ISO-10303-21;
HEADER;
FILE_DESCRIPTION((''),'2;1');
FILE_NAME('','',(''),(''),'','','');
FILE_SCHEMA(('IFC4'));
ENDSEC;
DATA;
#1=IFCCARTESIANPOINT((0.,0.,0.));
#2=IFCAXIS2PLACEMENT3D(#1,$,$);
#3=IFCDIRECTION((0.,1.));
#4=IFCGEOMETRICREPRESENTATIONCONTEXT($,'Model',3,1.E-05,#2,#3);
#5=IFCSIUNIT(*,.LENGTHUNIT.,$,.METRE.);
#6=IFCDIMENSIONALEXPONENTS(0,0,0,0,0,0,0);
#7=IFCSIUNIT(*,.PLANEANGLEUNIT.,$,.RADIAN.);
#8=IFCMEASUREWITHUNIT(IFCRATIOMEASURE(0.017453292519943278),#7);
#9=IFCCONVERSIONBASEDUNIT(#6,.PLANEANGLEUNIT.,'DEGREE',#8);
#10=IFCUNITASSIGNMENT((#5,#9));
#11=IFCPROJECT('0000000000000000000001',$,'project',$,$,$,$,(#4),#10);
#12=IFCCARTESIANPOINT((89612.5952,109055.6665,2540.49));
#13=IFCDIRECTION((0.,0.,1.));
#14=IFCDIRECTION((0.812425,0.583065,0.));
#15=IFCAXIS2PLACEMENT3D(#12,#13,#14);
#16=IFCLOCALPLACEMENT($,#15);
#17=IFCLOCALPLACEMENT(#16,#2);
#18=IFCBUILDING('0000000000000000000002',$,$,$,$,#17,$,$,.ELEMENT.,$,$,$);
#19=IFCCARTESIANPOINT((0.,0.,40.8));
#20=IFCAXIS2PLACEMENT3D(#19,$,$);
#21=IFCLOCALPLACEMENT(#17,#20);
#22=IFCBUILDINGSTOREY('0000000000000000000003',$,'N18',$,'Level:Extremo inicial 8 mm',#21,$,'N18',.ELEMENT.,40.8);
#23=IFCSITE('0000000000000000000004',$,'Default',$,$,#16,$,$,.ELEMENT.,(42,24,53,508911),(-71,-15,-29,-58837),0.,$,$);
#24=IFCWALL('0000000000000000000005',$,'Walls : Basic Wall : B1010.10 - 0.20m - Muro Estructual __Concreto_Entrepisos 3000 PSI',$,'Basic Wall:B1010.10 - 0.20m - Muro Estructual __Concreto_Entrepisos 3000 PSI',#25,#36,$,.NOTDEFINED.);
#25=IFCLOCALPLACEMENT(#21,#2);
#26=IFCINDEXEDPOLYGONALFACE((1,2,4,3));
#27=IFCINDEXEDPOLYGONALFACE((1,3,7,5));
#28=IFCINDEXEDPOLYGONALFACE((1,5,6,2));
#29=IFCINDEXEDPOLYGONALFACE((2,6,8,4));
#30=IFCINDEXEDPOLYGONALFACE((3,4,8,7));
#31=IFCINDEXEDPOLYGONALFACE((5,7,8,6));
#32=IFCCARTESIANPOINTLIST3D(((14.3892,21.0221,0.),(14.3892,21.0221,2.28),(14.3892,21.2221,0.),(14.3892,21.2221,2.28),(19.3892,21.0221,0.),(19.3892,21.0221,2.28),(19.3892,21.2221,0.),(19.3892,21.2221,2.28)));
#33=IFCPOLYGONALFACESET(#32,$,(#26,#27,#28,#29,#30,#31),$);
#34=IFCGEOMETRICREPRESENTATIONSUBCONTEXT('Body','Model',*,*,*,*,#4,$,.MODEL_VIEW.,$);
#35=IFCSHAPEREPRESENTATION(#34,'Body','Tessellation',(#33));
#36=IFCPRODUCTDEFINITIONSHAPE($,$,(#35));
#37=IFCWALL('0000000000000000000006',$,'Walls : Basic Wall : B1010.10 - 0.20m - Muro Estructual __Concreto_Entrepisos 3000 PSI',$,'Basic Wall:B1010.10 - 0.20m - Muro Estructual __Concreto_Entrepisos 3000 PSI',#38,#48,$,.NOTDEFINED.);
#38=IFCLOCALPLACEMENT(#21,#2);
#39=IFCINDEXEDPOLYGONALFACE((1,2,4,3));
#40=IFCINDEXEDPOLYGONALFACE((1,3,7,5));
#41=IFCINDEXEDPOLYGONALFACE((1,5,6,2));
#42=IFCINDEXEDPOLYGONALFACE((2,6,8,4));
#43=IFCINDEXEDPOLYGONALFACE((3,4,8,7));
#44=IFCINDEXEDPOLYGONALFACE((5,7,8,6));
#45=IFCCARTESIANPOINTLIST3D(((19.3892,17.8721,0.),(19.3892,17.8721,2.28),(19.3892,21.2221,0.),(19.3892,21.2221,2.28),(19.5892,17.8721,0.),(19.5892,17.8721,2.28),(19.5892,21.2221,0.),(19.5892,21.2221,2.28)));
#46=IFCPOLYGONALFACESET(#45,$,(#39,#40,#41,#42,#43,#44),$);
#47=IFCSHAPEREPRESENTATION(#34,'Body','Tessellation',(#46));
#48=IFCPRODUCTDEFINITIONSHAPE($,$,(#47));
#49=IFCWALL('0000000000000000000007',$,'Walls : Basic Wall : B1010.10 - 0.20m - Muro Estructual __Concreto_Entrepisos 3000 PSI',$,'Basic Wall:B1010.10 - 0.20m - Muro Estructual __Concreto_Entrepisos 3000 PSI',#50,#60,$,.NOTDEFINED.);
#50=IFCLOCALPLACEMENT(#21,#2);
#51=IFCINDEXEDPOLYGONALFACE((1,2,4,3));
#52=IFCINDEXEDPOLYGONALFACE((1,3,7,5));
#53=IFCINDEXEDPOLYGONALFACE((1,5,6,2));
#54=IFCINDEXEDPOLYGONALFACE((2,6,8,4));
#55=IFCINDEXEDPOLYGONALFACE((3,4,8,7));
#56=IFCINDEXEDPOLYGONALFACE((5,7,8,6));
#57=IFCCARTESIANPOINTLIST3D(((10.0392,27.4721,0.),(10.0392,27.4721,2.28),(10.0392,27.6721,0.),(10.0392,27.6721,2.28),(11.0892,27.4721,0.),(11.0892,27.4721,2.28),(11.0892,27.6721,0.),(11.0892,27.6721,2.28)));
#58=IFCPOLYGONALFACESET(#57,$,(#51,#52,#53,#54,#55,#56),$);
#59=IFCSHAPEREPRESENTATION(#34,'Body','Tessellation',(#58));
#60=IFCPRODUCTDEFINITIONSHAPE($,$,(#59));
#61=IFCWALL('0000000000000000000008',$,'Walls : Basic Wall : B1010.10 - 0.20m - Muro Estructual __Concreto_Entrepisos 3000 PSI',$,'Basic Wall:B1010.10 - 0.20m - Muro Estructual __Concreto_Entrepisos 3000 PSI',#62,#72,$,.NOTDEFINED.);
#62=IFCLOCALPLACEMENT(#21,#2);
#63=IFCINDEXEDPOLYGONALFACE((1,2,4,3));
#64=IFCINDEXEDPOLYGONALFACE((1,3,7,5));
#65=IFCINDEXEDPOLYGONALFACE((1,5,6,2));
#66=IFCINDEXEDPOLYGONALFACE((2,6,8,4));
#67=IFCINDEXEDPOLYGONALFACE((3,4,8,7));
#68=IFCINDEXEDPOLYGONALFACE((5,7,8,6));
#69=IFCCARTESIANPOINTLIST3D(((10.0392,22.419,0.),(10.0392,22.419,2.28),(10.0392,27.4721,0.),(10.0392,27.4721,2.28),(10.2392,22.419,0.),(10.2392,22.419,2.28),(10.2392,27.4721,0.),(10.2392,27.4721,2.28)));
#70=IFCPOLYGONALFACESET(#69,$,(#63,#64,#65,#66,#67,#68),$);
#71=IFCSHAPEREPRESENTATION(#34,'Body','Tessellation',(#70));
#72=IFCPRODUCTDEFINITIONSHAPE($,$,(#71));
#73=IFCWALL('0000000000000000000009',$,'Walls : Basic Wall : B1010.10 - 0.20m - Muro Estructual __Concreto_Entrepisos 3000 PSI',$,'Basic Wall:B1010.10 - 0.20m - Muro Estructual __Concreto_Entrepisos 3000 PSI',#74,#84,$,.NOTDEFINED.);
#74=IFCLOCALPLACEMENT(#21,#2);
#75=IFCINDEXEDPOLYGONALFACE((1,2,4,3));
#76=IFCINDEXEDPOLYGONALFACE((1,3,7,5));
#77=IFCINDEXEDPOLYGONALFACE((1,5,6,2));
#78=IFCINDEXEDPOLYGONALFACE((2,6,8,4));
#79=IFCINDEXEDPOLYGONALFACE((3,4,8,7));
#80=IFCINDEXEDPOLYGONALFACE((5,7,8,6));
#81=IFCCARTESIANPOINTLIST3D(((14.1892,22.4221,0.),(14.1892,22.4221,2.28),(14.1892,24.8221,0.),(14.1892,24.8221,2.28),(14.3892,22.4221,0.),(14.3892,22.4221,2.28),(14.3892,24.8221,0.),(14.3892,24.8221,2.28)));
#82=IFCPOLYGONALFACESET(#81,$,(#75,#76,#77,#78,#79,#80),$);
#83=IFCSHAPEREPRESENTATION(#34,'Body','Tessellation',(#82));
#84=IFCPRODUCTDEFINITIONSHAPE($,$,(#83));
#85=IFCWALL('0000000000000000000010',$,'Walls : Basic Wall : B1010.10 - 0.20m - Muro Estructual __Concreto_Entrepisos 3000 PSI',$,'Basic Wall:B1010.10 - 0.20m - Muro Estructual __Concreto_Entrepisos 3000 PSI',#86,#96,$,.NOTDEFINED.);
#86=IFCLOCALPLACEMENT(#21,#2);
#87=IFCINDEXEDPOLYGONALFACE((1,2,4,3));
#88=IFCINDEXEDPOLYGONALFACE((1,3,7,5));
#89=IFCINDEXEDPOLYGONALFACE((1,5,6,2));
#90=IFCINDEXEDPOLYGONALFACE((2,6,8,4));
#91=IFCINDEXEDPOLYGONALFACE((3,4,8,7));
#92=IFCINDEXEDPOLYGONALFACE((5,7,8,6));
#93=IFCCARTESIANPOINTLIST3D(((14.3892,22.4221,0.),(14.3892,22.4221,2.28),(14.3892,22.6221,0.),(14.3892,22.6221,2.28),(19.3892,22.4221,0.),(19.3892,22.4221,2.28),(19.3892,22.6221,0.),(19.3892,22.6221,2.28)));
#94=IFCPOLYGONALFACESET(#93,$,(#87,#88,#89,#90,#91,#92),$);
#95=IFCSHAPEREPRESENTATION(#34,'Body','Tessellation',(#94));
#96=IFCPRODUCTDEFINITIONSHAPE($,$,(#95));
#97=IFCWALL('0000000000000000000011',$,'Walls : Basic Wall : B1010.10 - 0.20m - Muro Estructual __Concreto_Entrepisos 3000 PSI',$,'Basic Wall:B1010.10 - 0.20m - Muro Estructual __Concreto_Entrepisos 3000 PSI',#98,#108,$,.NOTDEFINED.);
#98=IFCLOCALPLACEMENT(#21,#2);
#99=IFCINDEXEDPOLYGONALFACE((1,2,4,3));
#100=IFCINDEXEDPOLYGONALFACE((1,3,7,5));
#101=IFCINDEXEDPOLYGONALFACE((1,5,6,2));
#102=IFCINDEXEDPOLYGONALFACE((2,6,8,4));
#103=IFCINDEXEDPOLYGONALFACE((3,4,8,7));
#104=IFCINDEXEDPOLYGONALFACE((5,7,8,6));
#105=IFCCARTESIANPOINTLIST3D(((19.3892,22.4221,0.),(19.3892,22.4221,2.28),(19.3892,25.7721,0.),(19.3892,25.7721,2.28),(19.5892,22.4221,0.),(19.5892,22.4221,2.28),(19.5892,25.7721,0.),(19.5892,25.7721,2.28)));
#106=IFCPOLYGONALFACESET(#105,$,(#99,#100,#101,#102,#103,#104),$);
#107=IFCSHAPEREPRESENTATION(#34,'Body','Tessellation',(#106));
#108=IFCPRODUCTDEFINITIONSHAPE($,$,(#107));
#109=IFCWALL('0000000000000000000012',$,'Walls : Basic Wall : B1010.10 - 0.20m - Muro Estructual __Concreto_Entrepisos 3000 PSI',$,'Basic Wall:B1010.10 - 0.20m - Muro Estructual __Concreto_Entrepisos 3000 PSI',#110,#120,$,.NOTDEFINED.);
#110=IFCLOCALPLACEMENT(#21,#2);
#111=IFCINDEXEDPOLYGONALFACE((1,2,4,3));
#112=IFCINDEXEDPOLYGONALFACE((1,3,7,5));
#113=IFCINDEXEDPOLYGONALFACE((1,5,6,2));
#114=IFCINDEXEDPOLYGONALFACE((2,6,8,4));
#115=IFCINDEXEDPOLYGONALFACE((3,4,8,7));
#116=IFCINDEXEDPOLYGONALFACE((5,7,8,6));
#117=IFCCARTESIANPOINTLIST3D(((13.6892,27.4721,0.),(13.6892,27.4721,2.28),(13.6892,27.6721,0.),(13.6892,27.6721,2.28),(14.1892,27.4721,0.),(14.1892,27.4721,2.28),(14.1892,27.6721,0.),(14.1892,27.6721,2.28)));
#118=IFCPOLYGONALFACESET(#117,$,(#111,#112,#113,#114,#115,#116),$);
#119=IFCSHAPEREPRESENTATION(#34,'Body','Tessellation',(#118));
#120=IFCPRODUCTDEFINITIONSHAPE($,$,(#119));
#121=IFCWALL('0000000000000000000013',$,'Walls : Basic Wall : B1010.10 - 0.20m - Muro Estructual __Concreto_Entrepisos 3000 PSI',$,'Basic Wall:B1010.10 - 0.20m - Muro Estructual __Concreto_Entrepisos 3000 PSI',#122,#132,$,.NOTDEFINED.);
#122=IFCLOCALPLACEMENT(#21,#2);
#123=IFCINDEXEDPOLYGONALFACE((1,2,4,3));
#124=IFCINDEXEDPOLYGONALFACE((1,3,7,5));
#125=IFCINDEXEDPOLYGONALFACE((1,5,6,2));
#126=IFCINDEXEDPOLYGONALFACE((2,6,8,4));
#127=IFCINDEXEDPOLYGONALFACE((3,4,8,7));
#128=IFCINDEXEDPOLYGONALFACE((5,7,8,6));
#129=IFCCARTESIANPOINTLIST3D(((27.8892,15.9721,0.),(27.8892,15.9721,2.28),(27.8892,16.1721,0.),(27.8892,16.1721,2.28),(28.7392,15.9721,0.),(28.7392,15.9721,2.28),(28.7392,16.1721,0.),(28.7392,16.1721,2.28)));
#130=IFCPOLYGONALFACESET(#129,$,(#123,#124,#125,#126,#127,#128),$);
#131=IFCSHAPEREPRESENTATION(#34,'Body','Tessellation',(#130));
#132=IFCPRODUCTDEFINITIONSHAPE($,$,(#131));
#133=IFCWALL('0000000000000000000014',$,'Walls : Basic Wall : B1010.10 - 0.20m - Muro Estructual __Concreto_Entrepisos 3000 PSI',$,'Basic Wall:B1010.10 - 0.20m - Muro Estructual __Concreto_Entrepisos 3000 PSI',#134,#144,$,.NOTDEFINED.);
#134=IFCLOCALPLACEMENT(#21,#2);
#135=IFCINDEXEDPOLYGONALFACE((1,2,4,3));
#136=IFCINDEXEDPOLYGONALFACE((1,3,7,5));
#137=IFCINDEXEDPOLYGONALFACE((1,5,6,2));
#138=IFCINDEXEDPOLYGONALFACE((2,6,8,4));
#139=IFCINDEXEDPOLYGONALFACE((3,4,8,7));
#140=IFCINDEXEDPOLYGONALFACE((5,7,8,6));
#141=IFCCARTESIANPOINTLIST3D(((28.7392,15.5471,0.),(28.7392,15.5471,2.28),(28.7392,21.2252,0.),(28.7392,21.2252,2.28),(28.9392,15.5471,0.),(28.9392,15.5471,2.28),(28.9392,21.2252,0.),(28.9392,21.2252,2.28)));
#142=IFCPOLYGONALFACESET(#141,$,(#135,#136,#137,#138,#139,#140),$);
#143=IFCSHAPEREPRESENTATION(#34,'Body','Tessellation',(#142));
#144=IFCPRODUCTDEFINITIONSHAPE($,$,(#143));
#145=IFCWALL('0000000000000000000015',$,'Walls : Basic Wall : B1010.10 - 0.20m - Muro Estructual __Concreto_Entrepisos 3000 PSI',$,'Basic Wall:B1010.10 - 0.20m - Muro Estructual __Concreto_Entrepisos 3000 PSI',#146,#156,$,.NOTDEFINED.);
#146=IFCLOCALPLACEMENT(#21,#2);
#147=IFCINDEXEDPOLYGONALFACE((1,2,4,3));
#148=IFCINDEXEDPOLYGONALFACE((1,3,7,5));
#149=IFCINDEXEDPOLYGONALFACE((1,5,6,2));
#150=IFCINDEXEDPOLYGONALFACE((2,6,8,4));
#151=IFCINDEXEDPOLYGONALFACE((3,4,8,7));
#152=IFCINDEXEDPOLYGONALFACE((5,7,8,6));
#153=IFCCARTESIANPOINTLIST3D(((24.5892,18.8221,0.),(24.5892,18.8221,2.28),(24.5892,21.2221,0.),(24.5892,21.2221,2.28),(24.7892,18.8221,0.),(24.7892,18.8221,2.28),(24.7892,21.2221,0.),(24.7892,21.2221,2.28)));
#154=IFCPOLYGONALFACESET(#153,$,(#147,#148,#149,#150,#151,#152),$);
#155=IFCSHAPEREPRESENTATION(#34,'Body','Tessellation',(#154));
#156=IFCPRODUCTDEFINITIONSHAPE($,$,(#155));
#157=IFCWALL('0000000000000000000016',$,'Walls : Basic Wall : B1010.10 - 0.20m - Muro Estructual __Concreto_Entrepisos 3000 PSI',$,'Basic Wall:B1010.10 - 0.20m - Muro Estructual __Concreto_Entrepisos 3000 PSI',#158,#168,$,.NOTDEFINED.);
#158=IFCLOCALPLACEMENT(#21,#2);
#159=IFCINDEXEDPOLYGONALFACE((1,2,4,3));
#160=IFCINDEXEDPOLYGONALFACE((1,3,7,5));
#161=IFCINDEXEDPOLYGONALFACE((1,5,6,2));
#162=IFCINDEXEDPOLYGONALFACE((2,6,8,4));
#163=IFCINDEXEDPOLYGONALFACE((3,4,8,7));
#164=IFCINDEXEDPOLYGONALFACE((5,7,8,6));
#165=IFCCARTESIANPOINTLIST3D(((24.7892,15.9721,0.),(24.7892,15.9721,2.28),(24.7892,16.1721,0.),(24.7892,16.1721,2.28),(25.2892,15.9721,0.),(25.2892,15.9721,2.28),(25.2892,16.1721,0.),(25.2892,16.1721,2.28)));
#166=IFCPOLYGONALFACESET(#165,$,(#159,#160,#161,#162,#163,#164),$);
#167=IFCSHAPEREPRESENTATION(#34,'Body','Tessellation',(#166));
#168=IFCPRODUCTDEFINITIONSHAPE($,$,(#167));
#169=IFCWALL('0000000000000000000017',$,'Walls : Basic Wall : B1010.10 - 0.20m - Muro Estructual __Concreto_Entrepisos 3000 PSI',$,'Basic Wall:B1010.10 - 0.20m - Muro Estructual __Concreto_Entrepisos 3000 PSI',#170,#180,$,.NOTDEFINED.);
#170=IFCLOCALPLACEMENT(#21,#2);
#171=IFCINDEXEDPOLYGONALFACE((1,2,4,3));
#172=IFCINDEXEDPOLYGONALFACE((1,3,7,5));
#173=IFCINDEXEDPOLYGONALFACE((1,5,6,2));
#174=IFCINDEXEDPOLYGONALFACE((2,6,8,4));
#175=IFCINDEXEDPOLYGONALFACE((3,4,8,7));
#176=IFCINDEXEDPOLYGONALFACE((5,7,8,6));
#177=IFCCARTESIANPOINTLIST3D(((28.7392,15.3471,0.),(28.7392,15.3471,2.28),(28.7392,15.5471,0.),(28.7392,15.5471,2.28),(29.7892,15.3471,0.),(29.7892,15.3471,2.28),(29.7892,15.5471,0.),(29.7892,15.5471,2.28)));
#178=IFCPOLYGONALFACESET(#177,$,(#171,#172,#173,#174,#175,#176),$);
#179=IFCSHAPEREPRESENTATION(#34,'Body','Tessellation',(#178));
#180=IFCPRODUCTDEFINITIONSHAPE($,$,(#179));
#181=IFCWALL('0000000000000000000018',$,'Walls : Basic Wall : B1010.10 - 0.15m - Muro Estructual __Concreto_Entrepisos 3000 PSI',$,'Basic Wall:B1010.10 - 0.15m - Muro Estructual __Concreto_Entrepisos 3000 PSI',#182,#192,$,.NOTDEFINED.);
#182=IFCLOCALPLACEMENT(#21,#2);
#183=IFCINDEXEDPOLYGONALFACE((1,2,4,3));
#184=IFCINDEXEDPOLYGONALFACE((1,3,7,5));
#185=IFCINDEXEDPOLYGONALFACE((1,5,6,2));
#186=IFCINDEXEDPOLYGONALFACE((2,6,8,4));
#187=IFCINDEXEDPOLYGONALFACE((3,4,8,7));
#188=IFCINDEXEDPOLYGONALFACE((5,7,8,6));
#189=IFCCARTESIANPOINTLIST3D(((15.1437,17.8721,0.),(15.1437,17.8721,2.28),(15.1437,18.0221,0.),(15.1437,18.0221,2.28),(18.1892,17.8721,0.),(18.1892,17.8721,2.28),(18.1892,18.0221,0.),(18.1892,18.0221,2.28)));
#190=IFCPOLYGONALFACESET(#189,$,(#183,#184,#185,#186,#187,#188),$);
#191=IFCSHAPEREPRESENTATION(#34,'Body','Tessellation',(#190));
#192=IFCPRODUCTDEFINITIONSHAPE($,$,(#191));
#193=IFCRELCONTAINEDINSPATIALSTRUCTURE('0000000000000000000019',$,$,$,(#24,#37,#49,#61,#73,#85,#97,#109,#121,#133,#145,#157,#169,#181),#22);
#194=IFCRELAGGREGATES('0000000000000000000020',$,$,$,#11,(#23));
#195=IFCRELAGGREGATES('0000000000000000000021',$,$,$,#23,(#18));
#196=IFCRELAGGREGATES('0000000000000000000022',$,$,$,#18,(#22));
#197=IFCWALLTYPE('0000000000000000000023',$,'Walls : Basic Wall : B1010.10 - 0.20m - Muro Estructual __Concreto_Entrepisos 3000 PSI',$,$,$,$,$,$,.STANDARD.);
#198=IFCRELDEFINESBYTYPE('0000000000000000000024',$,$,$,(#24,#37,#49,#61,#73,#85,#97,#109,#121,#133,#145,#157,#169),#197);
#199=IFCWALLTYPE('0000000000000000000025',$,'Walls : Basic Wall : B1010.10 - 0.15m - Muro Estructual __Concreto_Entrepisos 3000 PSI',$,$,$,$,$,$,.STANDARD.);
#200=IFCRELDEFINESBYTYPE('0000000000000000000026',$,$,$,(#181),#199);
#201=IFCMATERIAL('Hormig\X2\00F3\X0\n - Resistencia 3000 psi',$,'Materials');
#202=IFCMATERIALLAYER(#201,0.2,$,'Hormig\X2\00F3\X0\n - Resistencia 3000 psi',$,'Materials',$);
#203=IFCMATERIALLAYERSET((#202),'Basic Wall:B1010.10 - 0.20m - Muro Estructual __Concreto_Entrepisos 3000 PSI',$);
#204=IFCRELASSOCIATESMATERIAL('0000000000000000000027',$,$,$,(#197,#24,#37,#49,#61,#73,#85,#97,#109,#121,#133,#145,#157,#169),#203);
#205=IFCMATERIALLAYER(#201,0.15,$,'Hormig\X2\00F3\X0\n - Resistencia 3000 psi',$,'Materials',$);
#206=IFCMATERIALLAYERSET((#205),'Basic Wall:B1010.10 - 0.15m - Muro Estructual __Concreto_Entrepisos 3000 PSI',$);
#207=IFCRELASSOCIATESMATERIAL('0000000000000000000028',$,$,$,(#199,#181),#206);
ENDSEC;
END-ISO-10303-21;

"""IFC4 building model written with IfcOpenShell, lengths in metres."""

from ifc_helpers import new_model, entity, si_unit, converted_unit, direction, frame, frame_2d, origin, place, context, subcontext, project, spatial, rectangle, extrude, material, layer, layer_set, layer_usage, type_object, element, save


model = new_model("IFC4")

# Units and contexts
model_context = context("Model", 3, precision=1e-05, world=origin(), true_north=direction((0.0, 1.0)))
body_context = subcontext(model_context, "Body", "Model", "MODEL_VIEW")
ifc_project = project(units=[si_unit("LENGTHUNIT", "METRE"), converted_unit("PLANEANGLEUNIT", "DEGREE", entity("IfcRatioMeasure", 0.017453292519943278), si_unit("PLANEANGLEUNIT", "RADIAN"), dimensions=[0, 0, 0, 0, 0, 0, 0])], contexts=[model_context])

# Site, building, storey
site_placement = place(None, frame((89612.5952, 109055.6665, 2540.49), z_axis=(0.0, 0.0, 1.0), x_axis=(0.812425, 0.583065, 0.0)))
site = spatial("IfcSite", under=ifc_project, at=site_placement, Name="Default", CompositionType="ELEMENT", RefLatitude=(42, 24, 53, 508911), RefLongitude=(-71, -15, -29, -58837), RefElevation=0.0)
building_placement = place(site_placement, origin())
building = spatial("IfcBuilding", under=site, at=building_placement, CompositionType="ELEMENT")
storey_placement = place(building_placement, frame((0.0, 0.0, 40.8)))
storey = spatial("IfcBuildingStorey", under=building, at=storey_placement, Name="N18", ObjectType="Level:Extremo inicial 8 mm", LongName="N18", CompositionType="ELEMENT", Elevation=40.8)

# Walls
ifc_material = material(Name="Hormigón - Resistencia 3000 psi", Category="Materials")
ifc_layer_1 = layer(ifc_material, 0.2, Name="Hormigón - Resistencia 3000 psi", Category="Materials")
ifc_layer_set_1 = layer_set([ifc_layer_1], Name="Basic Wall:B1010.10 - 0.20m - Muro Estructual __Concreto_Entrepisos 3000 PSI")
ifc_layer_usage_1 = layer_usage(ifc_layer_set_1, "AXIS2", "NEGATIVE", 0.1)
wall_type_1 = type_object("IfcWallType", Name="Walls : Basic Wall : B1010.10 - 0.20m - Muro Estructual __Concreto_Entrepisos 3000 PSI", PredefinedType="STANDARD", material=ifc_layer_set_1)
wall_1_placement = place(storey_placement, frame((14.3892, 21.1221, 0.0)))
element("IfcWall", 1, at=wall_1_placement, inside=storey, type_object=wall_type_1, material=ifc_layer_usage_1, Name="Walls : Basic Wall : B1010.10 - 0.20m - Muro Estructual __Concreto_Entrepisos 3000 PSI", ObjectType="Basic Wall:B1010.10 - 0.20m - Muro Estructual __Concreto_Entrepisos 3000 PSI", PredefinedType="NOTDEFINED", context=body_context, shape_type="SweptSolid", body=[
    extrude(rectangle(XDim=5.0, YDim=0.2, at=frame_2d((2.5, 0.0), x_axis=(-1.0, 0.0))), origin(), (0.0, 0.0, 1.0), 2.28),
])
ifc_layer_usage_2 = layer_usage(ifc_layer_set_1, "AXIS2", "NEGATIVE", 0.1)
wall_2_placement = place(storey_placement, frame((19.4892, 21.2221, 0.0), z_axis=(0.0, 0.0, 1.0), x_axis=(0.0, -1.0, 0.0)))
element("IfcWall", 2, at=wall_2_placement, inside=storey, type_object=wall_type_1, material=ifc_layer_usage_2, Name="Walls : Basic Wall : B1010.10 - 0.20m - Muro Estructual __Concreto_Entrepisos 3000 PSI", ObjectType="Basic Wall:B1010.10 - 0.20m - Muro Estructual __Concreto_Entrepisos 3000 PSI", PredefinedType="NOTDEFINED", context=body_context, shape_type="SweptSolid", body=[
    extrude(rectangle(XDim=3.35, YDim=0.2, at=frame_2d((1.675, 0.0), x_axis=(-1.0, 0.0))), origin(), (0.0, 0.0, 1.0), 2.28),
])
ifc_layer_usage_3 = layer_usage(ifc_layer_set_1, "AXIS2", "POSITIVE", -0.1)
wall_3_placement = place(storey_placement, frame((11.0892, 27.5721, 0.0), z_axis=(0.0, 0.0, 1.0), x_axis=(-1.0, 0.0, 0.0)))
element("IfcWall", 3, at=wall_3_placement, inside=storey, type_object=wall_type_1, material=ifc_layer_usage_3, Name="Walls : Basic Wall : B1010.10 - 0.20m - Muro Estructual __Concreto_Entrepisos 3000 PSI", ObjectType="Basic Wall:B1010.10 - 0.20m - Muro Estructual __Concreto_Entrepisos 3000 PSI", PredefinedType="NOTDEFINED", context=body_context, shape_type="SweptSolid", body=[
    extrude(rectangle(XDim=1.05, YDim=0.2, at=frame_2d((0.525, 0.0), x_axis=(-1.0, 0.0))), origin(), (0.0, 0.0, 1.0), 2.28),
])
ifc_layer_usage_4 = layer_usage(ifc_layer_set_1, "AXIS2", "POSITIVE", -0.1)
wall_4_placement = place(storey_placement, frame((10.1392, 27.4721, 0.0), z_axis=(0.0, 0.0, 1.0), x_axis=(0.0, -1.0, 0.0)))
element("IfcWall", 4, at=wall_4_placement, inside=storey, type_object=wall_type_1, material=ifc_layer_usage_4, Name="Walls : Basic Wall : B1010.10 - 0.20m - Muro Estructual __Concreto_Entrepisos 3000 PSI", ObjectType="Basic Wall:B1010.10 - 0.20m - Muro Estructual __Concreto_Entrepisos 3000 PSI", PredefinedType="NOTDEFINED", context=body_context, shape_type="SweptSolid", body=[
    extrude(rectangle(XDim=5.0531, YDim=0.2, at=frame_2d((2.5265, 0.0), x_axis=(-1.0, 0.0))), origin(), (0.0, 0.0, 1.0), 2.28),
])
ifc_layer_usage_5 = layer_usage(ifc_layer_set_1, "AXIS2", "POSITIVE", -0.1)
wall_5_placement = place(storey_placement, frame((14.2892, 24.8221, 0.0), z_axis=(0.0, 0.0, 1.0), x_axis=(0.0, -1.0, 0.0)))
element("IfcWall", 5, at=wall_5_placement, inside=storey, type_object=wall_type_1, material=ifc_layer_usage_5, Name="Walls : Basic Wall : B1010.10 - 0.20m - Muro Estructual __Concreto_Entrepisos 3000 PSI", ObjectType="Basic Wall:B1010.10 - 0.20m - Muro Estructual __Concreto_Entrepisos 3000 PSI", PredefinedType="NOTDEFINED", context=body_context, shape_type="SweptSolid", body=[
    extrude(rectangle(XDim=2.4, YDim=0.2, at=frame_2d((1.2, 0.0), x_axis=(-1.0, 0.0))), origin(), (0.0, 0.0, 1.0), 2.28),
])
ifc_layer_usage_6 = layer_usage(ifc_layer_set_1, "AXIS2", "POSITIVE", -0.1)
wall_6_placement = place(storey_placement, frame((14.3892, 22.5221, 0.0)))
element("IfcWall", 6, at=wall_6_placement, inside=storey, type_object=wall_type_1, material=ifc_layer_usage_6, Name="Walls : Basic Wall : B1010.10 - 0.20m - Muro Estructual __Concreto_Entrepisos 3000 PSI", ObjectType="Basic Wall:B1010.10 - 0.20m - Muro Estructual __Concreto_Entrepisos 3000 PSI", PredefinedType="NOTDEFINED", context=body_context, shape_type="SweptSolid", body=[
    extrude(rectangle(XDim=5.0, YDim=0.2, at=frame_2d((2.5, 0.0), x_axis=(-1.0, 0.0))), origin(), (0.0, 0.0, 1.0), 2.28),
])
ifc_layer_usage_7 = layer_usage(ifc_layer_set_1, "AXIS2", "POSITIVE", -0.1)
wall_7_placement = place(storey_placement, frame((19.4892, 22.4221, 0.0), z_axis=(0.0, 0.0, 1.0), x_axis=(0.0, 1.0, 0.0)))
element("IfcWall", 7, at=wall_7_placement, inside=storey, type_object=wall_type_1, material=ifc_layer_usage_7, Name="Walls : Basic Wall : B1010.10 - 0.20m - Muro Estructual __Concreto_Entrepisos 3000 PSI", ObjectType="Basic Wall:B1010.10 - 0.20m - Muro Estructual __Concreto_Entrepisos 3000 PSI", PredefinedType="NOTDEFINED", context=body_context, shape_type="SweptSolid", body=[
    extrude(rectangle(XDim=3.35, YDim=0.2, at=frame_2d((1.675, 0.0), x_axis=(-1.0, 0.0))), origin(), (0.0, 0.0, 1.0), 2.28),
])
ifc_layer_usage_8 = layer_usage(ifc_layer_set_1, "AXIS2", "POSITIVE", -0.1)
wall_8_placement = place(storey_placement, frame((13.6892, 27.5721, 0.0)))
element("IfcWall", 8, at=wall_8_placement, inside=storey, type_object=wall_type_1, material=ifc_layer_usage_8, Name="Walls : Basic Wall : B1010.10 - 0.20m - Muro Estructual __Concreto_Entrepisos 3000 PSI", ObjectType="Basic Wall:B1010.10 - 0.20m - Muro Estructual __Concreto_Entrepisos 3000 PSI", PredefinedType="NOTDEFINED", context=body_context, shape_type="SweptSolid", body=[
    extrude(rectangle(XDim=0.5, YDim=0.2, at=frame_2d((0.25, 0.0), x_axis=(-1.0, 0.0))), origin(), (0.0, 0.0, 1.0), 2.28),
])
ifc_layer_usage_9 = layer_usage(ifc_layer_set_1, "AXIS2", "POSITIVE", -0.1)
wall_9_placement = place(storey_placement, frame((27.8892, 16.0721, 0.0)))
element("IfcWall", 9, at=wall_9_placement, inside=storey, type_object=wall_type_1, material=ifc_layer_usage_9, Name="Walls : Basic Wall : B1010.10 - 0.20m - Muro Estructual __Concreto_Entrepisos 3000 PSI", ObjectType="Basic Wall:B1010.10 - 0.20m - Muro Estructual __Concreto_Entrepisos 3000 PSI", PredefinedType="NOTDEFINED", context=body_context, shape_type="SweptSolid", body=[
    extrude(rectangle(XDim=0.85, YDim=0.2, at=frame_2d((0.425, 0.0), x_axis=(-1.0, 0.0))), origin(), (0.0, 0.0, 1.0), 2.28),
])
ifc_layer_usage_10 = layer_usage(ifc_layer_set_1, "AXIS2", "POSITIVE", -0.1)
wall_10_placement = place(storey_placement, frame((28.8392, 15.5471, 0.0), z_axis=(0.0, 0.0, 1.0), x_axis=(0.0, 1.0, 0.0)))
element("IfcWall", 10, at=wall_10_placement, inside=storey, type_object=wall_type_1, material=ifc_layer_usage_10, Name="Walls : Basic Wall : B1010.10 - 0.20m - Muro Estructual __Concreto_Entrepisos 3000 PSI", ObjectType="Basic Wall:B1010.10 - 0.20m - Muro Estructual __Concreto_Entrepisos 3000 PSI", PredefinedType="NOTDEFINED", context=body_context, shape_type="SweptSolid", body=[
    extrude(rectangle(XDim=5.6781, YDim=0.2, at=frame_2d((2.839, 0.0), x_axis=(-1.0, 0.0))), origin(), (0.0, 0.0, 1.0), 2.28),
])
ifc_layer_usage_11 = layer_usage(ifc_layer_set_1, "AXIS2", "POSITIVE", -0.1)
wall_11_placement = place(storey_placement, frame((24.6892, 18.8221, 0.0), z_axis=(0.0, 0.0, 1.0), x_axis=(0.0, 1.0, 0.0)))
element("IfcWall", 11, at=wall_11_placement, inside=storey, type_object=wall_type_1, material=ifc_layer_usage_11, Name="Walls : Basic Wall : B1010.10 - 0.20m - Muro Estructual __Concreto_Entrepisos 3000 PSI", ObjectType="Basic Wall:B1010.10 - 0.20m - Muro Estructual __Concreto_Entrepisos 3000 PSI", PredefinedType="NOTDEFINED", context=body_context, shape_type="SweptSolid", body=[
    extrude(rectangle(XDim=2.4, YDim=0.2, at=frame_2d((1.2, 0.0), x_axis=(-1.0, 0.0))), origin(), (0.0, 0.0, 1.0), 2.28),
])
ifc_layer_usage_12 = layer_usage(ifc_layer_set_1, "AXIS2", "POSITIVE", -0.1)
wall_12_placement = place(storey_placement, frame((25.2892, 16.0721, 0.0), z_axis=(0.0, 0.0, 1.0), x_axis=(-1.0, 0.0, 0.0)))
element("IfcWall", 12, at=wall_12_placement, inside=storey, type_object=wall_type_1, material=ifc_layer_usage_12, Name="Walls : Basic Wall : B1010.10 - 0.20m - Muro Estructual __Concreto_Entrepisos 3000 PSI", ObjectType="Basic Wall:B1010.10 - 0.20m - Muro Estructual __Concreto_Entrepisos 3000 PSI", PredefinedType="NOTDEFINED", context=body_context, shape_type="SweptSolid", body=[
    extrude(rectangle(XDim=0.5, YDim=0.2, at=frame_2d((0.25, 0.0), x_axis=(-1.0, 0.0))), origin(), (0.0, 0.0, 1.0), 2.28),
])
ifc_layer_usage_13 = layer_usage(ifc_layer_set_1, "AXIS2", "NEGATIVE", 0.1)
wall_13_placement = place(storey_placement, frame((29.7892, 15.4471, 0.0), z_axis=(0.0, 0.0, 1.0), x_axis=(-1.0, 0.0, 0.0)))
element("IfcWall", 13, at=wall_13_placement, inside=storey, type_object=wall_type_1, material=ifc_layer_usage_13, Name="Walls : Basic Wall : B1010.10 - 0.20m - Muro Estructual __Concreto_Entrepisos 3000 PSI", ObjectType="Basic Wall:B1010.10 - 0.20m - Muro Estructual __Concreto_Entrepisos 3000 PSI", PredefinedType="NOTDEFINED", context=body_context, shape_type="SweptSolid", body=[
    extrude(rectangle(XDim=1.05, YDim=0.2, at=frame_2d((0.525, 0.0), x_axis=(-1.0, 0.0))), origin(), (0.0, 0.0, 1.0), 2.28),
])
ifc_layer_2 = layer(ifc_material, 0.15, Name="Hormigón - Resistencia 3000 psi", Category="Materials")
ifc_layer_set_2 = layer_set([ifc_layer_2], Name="Basic Wall:B1010.10 - 0.15m - Muro Estructual __Concreto_Entrepisos 3000 PSI")
ifc_layer_usage_14 = layer_usage(ifc_layer_set_2, "AXIS2", "NEGATIVE", 0.075)
wall_type_2 = type_object("IfcWallType", Name="Walls : Basic Wall : B1010.10 - 0.15m - Muro Estructual __Concreto_Entrepisos 3000 PSI", PredefinedType="STANDARD", material=ifc_layer_set_2)
wall_14_placement = place(storey_placement, frame((18.1892, 17.9471, 0.0), z_axis=(0.0, 0.0, 1.0), x_axis=(-1.0, 0.0, 0.0)))
element("IfcWall", 14, at=wall_14_placement, inside=storey, type_object=wall_type_2, material=ifc_layer_usage_14, Name="Walls : Basic Wall : B1010.10 - 0.15m - Muro Estructual __Concreto_Entrepisos 3000 PSI", ObjectType="Basic Wall:B1010.10 - 0.15m - Muro Estructual __Concreto_Entrepisos 3000 PSI", PredefinedType="NOTDEFINED", context=body_context, shape_type="SweptSolid", body=[
    extrude(rectangle(XDim=3.0455, YDim=0.15, at=frame_2d((1.5228, 0.0), x_axis=(-1.0, 0.0))), origin(), (0.0, 0.0, 1.0), 2.28),
])

save(model, "model.ifc")
